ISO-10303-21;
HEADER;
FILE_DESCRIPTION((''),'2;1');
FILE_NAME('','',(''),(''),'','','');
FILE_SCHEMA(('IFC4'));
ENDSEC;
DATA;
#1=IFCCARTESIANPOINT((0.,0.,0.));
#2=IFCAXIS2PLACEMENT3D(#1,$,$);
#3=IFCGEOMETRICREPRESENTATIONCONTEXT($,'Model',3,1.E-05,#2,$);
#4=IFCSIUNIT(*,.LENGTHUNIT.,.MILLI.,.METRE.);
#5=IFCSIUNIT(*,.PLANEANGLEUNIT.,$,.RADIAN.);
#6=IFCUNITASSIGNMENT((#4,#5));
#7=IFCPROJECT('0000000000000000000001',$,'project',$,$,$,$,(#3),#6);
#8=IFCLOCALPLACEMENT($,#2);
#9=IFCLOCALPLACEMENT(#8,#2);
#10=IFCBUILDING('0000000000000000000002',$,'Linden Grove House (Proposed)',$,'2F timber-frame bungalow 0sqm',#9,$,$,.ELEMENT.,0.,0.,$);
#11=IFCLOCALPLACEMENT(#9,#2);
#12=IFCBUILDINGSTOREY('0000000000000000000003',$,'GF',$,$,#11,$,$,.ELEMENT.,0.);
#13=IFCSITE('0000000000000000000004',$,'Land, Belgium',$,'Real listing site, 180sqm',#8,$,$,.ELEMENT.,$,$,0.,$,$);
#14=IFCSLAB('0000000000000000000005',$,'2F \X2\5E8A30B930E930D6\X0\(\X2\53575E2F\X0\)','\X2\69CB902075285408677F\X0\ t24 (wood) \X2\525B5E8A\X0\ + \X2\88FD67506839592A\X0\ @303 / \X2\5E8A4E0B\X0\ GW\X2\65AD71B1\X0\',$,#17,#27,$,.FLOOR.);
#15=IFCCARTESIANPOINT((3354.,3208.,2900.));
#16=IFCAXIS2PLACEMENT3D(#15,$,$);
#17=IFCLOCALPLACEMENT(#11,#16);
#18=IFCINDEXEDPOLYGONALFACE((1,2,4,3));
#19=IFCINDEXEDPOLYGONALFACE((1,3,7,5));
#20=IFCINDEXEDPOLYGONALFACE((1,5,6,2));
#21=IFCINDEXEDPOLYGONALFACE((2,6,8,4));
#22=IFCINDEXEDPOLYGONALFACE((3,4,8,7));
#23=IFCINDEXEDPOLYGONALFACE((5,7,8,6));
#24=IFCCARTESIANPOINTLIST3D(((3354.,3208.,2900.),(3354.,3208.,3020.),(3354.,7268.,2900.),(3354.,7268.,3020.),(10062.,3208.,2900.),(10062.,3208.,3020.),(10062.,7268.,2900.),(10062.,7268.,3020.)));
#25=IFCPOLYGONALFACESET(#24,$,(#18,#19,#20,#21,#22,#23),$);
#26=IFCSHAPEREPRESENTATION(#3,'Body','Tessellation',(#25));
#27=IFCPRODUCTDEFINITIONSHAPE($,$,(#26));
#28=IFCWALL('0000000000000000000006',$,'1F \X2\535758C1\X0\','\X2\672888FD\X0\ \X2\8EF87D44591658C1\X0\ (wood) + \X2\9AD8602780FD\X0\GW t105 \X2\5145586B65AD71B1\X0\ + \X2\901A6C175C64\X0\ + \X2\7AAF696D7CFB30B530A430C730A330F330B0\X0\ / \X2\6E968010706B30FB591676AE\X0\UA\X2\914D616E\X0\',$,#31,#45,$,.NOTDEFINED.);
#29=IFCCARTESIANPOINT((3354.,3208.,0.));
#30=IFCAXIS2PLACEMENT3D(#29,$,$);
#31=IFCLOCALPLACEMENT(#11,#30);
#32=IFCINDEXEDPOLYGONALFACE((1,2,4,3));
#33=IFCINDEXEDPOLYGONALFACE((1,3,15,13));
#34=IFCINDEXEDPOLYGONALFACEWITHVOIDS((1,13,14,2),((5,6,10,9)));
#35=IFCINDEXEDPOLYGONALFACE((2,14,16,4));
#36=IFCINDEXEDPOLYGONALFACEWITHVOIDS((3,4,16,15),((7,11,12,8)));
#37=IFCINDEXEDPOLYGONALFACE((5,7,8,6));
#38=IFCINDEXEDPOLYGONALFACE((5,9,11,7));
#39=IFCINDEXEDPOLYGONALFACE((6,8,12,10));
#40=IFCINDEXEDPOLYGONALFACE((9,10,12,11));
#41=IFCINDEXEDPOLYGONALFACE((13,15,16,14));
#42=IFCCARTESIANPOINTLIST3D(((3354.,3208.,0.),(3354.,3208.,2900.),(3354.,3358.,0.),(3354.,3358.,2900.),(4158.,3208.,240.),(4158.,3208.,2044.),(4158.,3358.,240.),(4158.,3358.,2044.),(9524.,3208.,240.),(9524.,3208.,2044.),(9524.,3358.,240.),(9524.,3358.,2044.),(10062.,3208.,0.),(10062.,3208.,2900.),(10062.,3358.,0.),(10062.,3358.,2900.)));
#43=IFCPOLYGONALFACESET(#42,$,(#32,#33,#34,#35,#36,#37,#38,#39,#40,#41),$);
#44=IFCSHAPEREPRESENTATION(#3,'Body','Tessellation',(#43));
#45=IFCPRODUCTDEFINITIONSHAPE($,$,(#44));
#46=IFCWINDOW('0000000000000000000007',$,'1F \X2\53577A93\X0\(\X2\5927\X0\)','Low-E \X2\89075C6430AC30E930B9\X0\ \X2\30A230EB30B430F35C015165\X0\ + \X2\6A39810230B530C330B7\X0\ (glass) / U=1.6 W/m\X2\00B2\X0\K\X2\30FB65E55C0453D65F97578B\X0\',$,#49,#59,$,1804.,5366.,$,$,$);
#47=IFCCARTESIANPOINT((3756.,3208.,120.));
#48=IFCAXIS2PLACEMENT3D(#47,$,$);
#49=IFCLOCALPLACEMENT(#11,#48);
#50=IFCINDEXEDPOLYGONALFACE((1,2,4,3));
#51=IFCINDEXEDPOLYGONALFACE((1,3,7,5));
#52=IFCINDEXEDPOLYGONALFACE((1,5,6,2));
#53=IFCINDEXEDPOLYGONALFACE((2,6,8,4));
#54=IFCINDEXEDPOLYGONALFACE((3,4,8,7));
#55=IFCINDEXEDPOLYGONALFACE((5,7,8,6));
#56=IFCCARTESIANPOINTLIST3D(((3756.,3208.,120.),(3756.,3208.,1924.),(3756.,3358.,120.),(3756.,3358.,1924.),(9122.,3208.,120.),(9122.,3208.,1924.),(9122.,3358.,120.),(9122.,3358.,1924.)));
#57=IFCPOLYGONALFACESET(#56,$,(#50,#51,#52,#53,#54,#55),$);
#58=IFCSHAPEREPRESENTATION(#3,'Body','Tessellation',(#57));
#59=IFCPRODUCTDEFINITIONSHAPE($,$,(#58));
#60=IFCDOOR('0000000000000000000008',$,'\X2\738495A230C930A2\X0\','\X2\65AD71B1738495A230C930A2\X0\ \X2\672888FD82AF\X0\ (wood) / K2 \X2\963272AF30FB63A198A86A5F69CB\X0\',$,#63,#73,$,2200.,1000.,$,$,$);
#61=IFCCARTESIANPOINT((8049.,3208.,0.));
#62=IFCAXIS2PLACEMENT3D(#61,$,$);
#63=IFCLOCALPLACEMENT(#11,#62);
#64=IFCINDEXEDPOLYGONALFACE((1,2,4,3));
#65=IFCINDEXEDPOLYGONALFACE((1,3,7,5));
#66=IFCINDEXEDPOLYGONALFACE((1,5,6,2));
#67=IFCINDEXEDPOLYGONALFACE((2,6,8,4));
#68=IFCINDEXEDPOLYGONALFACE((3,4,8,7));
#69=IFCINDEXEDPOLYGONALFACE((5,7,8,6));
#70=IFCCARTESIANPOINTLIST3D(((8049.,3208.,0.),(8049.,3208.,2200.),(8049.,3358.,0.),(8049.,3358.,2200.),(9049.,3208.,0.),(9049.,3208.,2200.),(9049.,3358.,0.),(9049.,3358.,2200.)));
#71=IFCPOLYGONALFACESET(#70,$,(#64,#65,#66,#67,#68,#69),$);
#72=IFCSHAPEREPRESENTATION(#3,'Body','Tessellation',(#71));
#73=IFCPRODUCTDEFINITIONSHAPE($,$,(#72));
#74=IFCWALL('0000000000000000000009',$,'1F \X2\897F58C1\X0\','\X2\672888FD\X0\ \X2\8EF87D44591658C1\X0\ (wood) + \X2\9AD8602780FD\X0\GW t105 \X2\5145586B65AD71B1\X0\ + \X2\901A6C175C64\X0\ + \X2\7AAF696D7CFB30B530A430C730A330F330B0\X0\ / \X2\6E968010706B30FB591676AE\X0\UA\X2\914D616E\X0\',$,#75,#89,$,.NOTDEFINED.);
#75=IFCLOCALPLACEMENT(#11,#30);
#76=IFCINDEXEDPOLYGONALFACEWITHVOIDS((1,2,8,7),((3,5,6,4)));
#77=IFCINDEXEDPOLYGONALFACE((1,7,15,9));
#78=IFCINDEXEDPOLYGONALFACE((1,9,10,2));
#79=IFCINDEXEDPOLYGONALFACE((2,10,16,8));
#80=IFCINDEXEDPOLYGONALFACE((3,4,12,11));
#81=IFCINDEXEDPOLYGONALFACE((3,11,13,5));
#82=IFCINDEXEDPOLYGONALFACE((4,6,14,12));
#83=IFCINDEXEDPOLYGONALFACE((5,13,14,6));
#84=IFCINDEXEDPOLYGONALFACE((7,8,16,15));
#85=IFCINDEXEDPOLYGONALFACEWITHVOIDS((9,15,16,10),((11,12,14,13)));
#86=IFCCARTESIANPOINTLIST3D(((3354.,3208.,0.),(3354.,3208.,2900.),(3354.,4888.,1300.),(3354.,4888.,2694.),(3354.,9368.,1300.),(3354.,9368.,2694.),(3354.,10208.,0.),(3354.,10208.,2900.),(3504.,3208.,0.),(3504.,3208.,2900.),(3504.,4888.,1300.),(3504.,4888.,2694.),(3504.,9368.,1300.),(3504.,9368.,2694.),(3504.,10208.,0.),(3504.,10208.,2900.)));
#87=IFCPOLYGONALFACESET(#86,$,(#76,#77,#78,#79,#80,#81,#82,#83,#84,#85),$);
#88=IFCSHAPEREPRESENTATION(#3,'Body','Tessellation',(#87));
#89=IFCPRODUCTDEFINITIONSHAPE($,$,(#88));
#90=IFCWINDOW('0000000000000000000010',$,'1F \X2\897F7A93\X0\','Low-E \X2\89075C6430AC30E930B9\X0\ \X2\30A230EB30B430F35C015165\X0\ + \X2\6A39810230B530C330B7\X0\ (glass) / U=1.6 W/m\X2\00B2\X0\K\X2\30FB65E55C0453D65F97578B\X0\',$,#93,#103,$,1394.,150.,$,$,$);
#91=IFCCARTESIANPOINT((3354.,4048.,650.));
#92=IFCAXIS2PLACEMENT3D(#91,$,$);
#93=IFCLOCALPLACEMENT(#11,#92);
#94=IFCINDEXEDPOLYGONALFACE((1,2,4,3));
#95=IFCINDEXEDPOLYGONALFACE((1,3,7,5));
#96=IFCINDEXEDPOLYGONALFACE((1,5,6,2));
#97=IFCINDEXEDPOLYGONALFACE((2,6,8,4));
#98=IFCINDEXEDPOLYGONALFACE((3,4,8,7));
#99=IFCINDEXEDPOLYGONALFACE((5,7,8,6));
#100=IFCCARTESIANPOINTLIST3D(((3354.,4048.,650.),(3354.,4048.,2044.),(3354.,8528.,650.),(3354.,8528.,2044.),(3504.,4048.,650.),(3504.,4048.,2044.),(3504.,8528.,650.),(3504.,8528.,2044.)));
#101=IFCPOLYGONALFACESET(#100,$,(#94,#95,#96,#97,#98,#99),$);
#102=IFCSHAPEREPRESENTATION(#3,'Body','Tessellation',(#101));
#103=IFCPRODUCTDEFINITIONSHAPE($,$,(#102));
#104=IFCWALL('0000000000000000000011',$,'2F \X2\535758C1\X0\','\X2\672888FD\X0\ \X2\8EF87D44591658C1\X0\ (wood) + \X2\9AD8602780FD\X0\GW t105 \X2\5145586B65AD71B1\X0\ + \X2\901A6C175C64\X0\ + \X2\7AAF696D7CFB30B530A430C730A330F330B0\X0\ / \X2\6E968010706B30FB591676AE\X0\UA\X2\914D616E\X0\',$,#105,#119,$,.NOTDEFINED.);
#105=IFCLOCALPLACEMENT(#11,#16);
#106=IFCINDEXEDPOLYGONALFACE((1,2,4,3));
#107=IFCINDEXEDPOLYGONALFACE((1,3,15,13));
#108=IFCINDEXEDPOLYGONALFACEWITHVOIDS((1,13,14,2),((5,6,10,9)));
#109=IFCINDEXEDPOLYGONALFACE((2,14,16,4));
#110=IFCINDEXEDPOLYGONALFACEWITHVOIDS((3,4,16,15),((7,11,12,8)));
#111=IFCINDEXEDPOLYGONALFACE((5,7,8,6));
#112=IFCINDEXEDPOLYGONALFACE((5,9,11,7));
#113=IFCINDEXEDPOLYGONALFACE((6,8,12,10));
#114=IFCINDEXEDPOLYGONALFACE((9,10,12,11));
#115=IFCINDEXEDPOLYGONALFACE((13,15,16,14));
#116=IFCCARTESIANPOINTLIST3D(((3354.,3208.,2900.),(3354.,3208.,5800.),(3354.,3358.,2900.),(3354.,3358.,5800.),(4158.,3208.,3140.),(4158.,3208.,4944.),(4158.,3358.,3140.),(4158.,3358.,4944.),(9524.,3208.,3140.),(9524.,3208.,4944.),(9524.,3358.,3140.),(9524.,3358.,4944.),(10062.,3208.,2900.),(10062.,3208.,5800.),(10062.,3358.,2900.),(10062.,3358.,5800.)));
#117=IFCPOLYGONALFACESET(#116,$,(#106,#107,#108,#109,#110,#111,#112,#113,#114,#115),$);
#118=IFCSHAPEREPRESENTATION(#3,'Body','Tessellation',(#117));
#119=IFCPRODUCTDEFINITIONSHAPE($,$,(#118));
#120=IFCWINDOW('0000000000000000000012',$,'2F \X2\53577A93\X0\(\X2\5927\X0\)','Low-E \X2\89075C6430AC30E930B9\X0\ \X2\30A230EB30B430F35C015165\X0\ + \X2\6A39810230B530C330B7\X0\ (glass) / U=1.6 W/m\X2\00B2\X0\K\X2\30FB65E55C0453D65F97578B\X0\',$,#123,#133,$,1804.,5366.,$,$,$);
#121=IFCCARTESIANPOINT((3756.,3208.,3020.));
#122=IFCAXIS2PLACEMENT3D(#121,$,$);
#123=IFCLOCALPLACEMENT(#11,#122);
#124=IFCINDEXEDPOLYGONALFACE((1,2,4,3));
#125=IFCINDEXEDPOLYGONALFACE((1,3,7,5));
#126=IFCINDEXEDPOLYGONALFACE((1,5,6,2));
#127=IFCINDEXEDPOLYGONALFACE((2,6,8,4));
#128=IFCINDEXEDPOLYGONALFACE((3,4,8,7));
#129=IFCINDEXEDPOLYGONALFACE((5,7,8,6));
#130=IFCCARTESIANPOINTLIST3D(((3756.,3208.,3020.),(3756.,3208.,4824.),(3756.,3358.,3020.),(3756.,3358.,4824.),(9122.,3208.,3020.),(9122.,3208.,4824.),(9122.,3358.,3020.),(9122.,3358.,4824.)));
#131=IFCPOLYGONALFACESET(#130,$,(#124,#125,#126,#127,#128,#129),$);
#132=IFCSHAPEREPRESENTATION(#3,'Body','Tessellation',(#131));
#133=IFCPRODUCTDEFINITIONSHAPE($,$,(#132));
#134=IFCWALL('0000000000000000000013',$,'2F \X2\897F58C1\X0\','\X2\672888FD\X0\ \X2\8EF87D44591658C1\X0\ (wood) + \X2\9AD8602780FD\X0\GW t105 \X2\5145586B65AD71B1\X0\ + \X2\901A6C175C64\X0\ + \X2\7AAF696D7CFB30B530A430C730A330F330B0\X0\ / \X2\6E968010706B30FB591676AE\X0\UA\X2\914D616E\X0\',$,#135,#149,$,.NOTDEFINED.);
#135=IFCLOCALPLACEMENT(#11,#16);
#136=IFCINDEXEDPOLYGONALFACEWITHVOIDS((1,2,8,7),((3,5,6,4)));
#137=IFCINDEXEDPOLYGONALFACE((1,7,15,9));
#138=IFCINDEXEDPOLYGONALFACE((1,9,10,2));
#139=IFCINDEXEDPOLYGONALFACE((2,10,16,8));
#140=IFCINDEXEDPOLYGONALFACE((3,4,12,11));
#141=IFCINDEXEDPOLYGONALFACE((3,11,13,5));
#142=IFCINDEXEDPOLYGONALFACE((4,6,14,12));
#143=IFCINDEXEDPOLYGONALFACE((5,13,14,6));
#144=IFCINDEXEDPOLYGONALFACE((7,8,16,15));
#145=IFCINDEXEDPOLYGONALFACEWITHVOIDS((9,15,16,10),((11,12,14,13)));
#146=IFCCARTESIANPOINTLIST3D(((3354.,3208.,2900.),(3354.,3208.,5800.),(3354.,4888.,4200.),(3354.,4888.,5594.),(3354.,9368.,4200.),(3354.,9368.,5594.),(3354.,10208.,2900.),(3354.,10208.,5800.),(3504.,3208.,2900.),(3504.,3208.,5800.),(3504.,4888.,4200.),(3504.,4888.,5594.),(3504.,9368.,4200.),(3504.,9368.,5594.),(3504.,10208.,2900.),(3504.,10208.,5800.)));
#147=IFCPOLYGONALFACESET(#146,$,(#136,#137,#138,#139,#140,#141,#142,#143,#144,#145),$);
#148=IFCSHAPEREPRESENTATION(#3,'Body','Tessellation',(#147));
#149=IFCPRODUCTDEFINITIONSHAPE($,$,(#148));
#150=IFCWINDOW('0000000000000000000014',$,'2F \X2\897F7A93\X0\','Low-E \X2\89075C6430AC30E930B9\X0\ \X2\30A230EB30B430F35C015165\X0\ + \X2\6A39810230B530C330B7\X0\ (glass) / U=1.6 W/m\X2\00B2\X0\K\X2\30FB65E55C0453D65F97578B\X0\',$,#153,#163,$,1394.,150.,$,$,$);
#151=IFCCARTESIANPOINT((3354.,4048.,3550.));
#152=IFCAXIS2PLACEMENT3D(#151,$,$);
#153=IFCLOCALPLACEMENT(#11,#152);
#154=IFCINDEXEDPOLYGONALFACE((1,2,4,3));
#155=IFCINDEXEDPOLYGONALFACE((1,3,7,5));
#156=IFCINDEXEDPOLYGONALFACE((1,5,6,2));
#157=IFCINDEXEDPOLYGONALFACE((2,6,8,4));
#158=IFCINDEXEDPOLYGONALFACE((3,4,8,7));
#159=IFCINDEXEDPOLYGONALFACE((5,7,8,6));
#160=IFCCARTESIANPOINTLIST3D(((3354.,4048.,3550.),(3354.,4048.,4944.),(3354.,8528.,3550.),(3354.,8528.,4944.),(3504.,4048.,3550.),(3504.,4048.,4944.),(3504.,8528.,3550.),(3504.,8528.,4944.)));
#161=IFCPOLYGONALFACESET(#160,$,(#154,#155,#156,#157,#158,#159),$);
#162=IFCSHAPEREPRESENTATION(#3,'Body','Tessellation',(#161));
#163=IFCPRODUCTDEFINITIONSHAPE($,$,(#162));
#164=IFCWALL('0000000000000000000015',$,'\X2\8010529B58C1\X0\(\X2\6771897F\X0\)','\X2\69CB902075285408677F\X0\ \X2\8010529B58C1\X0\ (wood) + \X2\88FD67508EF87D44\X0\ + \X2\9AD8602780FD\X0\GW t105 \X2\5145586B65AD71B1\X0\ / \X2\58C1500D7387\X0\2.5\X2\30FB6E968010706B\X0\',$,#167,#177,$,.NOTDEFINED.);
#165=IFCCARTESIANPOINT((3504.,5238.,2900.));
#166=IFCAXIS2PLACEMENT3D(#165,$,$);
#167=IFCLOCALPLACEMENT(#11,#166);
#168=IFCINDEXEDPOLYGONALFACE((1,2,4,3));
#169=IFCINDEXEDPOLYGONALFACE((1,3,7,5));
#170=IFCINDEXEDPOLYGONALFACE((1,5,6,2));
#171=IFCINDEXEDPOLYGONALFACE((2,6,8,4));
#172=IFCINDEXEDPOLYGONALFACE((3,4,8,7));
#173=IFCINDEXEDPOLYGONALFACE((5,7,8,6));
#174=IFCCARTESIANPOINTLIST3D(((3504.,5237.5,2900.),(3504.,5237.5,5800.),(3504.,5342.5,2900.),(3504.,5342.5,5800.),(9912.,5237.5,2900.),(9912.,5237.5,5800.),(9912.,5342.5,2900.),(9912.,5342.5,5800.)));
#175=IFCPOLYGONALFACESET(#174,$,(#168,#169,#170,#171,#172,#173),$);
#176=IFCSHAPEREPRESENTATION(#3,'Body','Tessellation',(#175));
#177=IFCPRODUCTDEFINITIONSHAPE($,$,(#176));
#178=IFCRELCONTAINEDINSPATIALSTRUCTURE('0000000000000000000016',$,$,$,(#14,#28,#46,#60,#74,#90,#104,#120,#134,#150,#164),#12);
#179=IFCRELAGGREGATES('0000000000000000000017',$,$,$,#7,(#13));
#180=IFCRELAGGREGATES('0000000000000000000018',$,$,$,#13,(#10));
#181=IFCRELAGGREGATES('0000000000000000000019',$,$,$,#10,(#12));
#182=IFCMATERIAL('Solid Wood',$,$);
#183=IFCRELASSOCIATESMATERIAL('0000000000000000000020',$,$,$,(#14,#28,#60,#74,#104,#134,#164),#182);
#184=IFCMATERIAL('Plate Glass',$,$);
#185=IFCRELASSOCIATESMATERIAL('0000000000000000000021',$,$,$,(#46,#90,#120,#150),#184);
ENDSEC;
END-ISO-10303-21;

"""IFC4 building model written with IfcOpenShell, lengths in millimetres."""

from ifc_helpers import new_model, si_unit, frame, frame_2d, origin, place, context, project, spatial, rectangle, extrude, material, element, fill, save


model = new_model("IFC4")

# Units and contexts
model_context = context("Model", 3, precision=1e-05, world=origin())
ifc_project = project(units=[si_unit("LENGTHUNIT", "METRE", prefix="MILLI"), si_unit("PLANEANGLEUNIT", "RADIAN")], contexts=[model_context])

# Site, building, storey
site_placement = place(None, origin())
site = spatial("IfcSite", under=ifc_project, at=site_placement, Name="Land, Belgium", ObjectType="Real listing site, 180sqm", CompositionType="ELEMENT", RefElevation=0.0)
building_placement = place(site_placement, origin())
building = spatial("IfcBuilding", under=site, at=building_placement, Name="Linden Grove House (Proposed)", ObjectType="2F timber-frame bungalow 0sqm", CompositionType="ELEMENT", ElevationOfRefHeight=0.0, ElevationOfTerrain=0.0)
storey_placement = place(building_placement, origin())
storey = spatial("IfcBuildingStorey", under=building, at=storey_placement, Name="GF", CompositionType="ELEMENT", Elevation=0.0)

# Slab
ifc_material_1 = material(Name="Solid Wood")
slab_1_placement = place(storey_placement, frame((3354.0, 3208.0, 2900.0)))
element("IfcSlab", 1, at=slab_1_placement, inside=storey, material=ifc_material_1, Name="2F 床スラブ(南帯)", Description="構造用合板 t24 (wood) 剛床 + 製材根太 @303 / 床下 GW断熱", PredefinedType="FLOOR", context=model_context, shape_type="SweptSolid", body=[
    extrude(rectangle(XDim=6708.0, YDim=4060.0, at=frame_2d((3354.0, 2030.0))), frame((3354.0, 3208.0, 2900.0)), (0.0, 0.0, 1.0), 120.0),
])

# Wall, openings, window, door
wall_1_placement = place(storey_placement, frame((3354.0, 3208.0, 0.0)))
wall_1 = element("IfcWall", 2, at=wall_1_placement, inside=storey, material=ifc_material_1, Name="1F 南壁", Description="木製 軸組外壁 (wood) + 高性能GW t105 充填断熱 + 通気層 + 窯業系サイディング / 準耐火・外皮UA配慮", PredefinedType="NOTDEFINED", context=model_context, shape_type="SweptSolid", body=[
    extrude(rectangle(XDim=6708.0, YDim=150.0, at=frame_2d((3354.0, 75.0))), frame((3354.0, 3208.0, 0.0)), (0.0, 0.0, 1.0), 2900.0),
])
opening_1_placement = place(storey_placement, frame((3756.0, 3208.0, 120.0)))
opening_1 = element("IfcOpeningElement", 3, at=opening_1_placement, cuts=wall_1, PredefinedType="NOTDEFINED", context=model_context, shape_type="SweptSolid", body=[
    extrude(rectangle(XDim=5366.0, YDim=150.0, at=frame_2d((2683.0, 75.0))), frame((3756.0, 3208.0, 120.0)), (0.0, 0.0, 1.0), 1804.0),
])
opening_2_placement = place(storey_placement, frame((8049.0, 3208.0, 0.0)))
opening_2 = element("IfcOpeningElement", 4, at=opening_2_placement, cuts=wall_1, PredefinedType="NOTDEFINED", context=model_context, shape_type="SweptSolid", body=[
    extrude(rectangle(XDim=1000.0, YDim=150.0, at=frame_2d((500.0, 75.0))), frame((8049.0, 3208.0, 0.0)), (0.0, 0.0, 1.0), 2200.0),
])
ifc_material_2 = material(Name="Plate Glass")
window_1_placement = place(storey_placement, frame((3756.0, 3208.0, 120.0)))
window_1 = element("IfcWindow", 5, at=window_1_placement, inside=storey, material=ifc_material_2, Name="1F 南窓(大)", Description="Low-E 複層ガラス アルゴン封入 + 樹脂サッシ (glass) / U=1.6 W/m²K・日射取得型", OverallHeight=1804.0, OverallWidth=5366.0, context=model_context, shape_type="SweptSolid", body=[
    extrude(rectangle(XDim=5366.0, YDim=150.0, at=frame_2d((2683.0, 75.0))), frame((3756.0, 3208.0, 120.0)), (0.0, 0.0, 1.0), 1804.0),
])
fill(opening_1, window_1)
door_placement = place(storey_placement, frame((8049.0, 3208.0, 0.0)))
door = element("IfcDoor", 6, at=door_placement, inside=storey, material=ifc_material_1, Name="玄関ドア", Description="断熱玄関ドア 木製芯 (wood) / K2 防犯・採風機構", OverallHeight=2200.0, OverallWidth=1000.0, context=model_context, shape_type="SweptSolid", body=[
    extrude(rectangle(XDim=1000.0, YDim=150.0, at=frame_2d((500.0, 75.0))), frame((8049.0, 3208.0, 0.0)), (0.0, 0.0, 1.0), 2200.0),
])
fill(opening_2, door)

# Wall, opening, window
wall_2_placement = place(storey_placement, frame((3354.0, 3208.0, 0.0)))
wall_2 = element("IfcWall", 7, at=wall_2_placement, inside=storey, material=ifc_material_1, Name="1F 西壁", Description="木製 軸組外壁 (wood) + 高性能GW t105 充填断熱 + 通気層 + 窯業系サイディング / 準耐火・外皮UA配慮", PredefinedType="NOTDEFINED", context=model_context, shape_type="SweptSolid", body=[
    extrude(rectangle(XDim=150.0, YDim=7000.0, at=frame_2d((75.0, 3500.0))), frame((3354.0, 3208.0, 0.0)), (0.0, 0.0, 1.0), 2900.0),
])
opening_3_placement = place(storey_placement, frame((3354.0, 4048.0, 650.0)))
opening_3 = element("IfcOpeningElement", 8, at=opening_3_placement, cuts=wall_2, PredefinedType="NOTDEFINED", context=model_context, shape_type="SweptSolid", body=[
    extrude(rectangle(XDim=150.0, YDim=4480.0, at=frame_2d((75.0, 2240.0))), frame((3354.0, 4048.0, 650.0)), (0.0, 0.0, 1.0), 1394.0),
])
window_2_placement = place(storey_placement, frame((3354.0, 4048.0, 650.0)))
window_2 = element("IfcWindow", 9, at=window_2_placement, inside=storey, material=ifc_material_2, Name="1F 西窓", Description="Low-E 複層ガラス アルゴン封入 + 樹脂サッシ (glass) / U=1.6 W/m²K・日射取得型", OverallHeight=1394.0, OverallWidth=150.0, context=model_context, shape_type="SweptSolid", body=[
    extrude(rectangle(XDim=150.0, YDim=4480.0, at=frame_2d((75.0, 2240.0))), frame((3354.0, 4048.0, 650.0)), (0.0, 0.0, 1.0), 1394.0),
])
fill(opening_3, window_2)

# Walls, openings, windows
wall_3_placement = place(storey_placement, frame((3354.0, 3208.0, 2900.0)))
wall_3 = element("IfcWall", 10, at=wall_3_placement, inside=storey, material=ifc_material_1, Name="2F 南壁", Description="木製 軸組外壁 (wood) + 高性能GW t105 充填断熱 + 通気層 + 窯業系サイディング / 準耐火・外皮UA配慮", PredefinedType="NOTDEFINED", context=model_context, shape_type="SweptSolid", body=[
    extrude(rectangle(XDim=6708.0, YDim=150.0, at=frame_2d((3354.0, 75.0))), frame((3354.0, 3208.0, 2900.0)), (0.0, 0.0, 1.0), 2900.0),
])
opening_4_placement = place(storey_placement, frame((3756.0, 3208.0, 3020.0)))
opening_4 = element("IfcOpeningElement", 11, at=opening_4_placement, cuts=wall_3, PredefinedType="NOTDEFINED", context=model_context, shape_type="SweptSolid", body=[
    extrude(rectangle(XDim=5366.0, YDim=150.0, at=frame_2d((2683.0, 75.0))), frame((3756.0, 3208.0, 3020.0)), (0.0, 0.0, 1.0), 1804.0),
])
window_3_placement = place(storey_placement, frame((3756.0, 3208.0, 3020.0)))
window_3 = element("IfcWindow", 12, at=window_3_placement, inside=storey, material=ifc_material_2, Name="2F 南窓(大)", Description="Low-E 複層ガラス アルゴン封入 + 樹脂サッシ (glass) / U=1.6 W/m²K・日射取得型", OverallHeight=1804.0, OverallWidth=5366.0, context=model_context, shape_type="SweptSolid", body=[
    extrude(rectangle(XDim=5366.0, YDim=150.0, at=frame_2d((2683.0, 75.0))), frame((3756.0, 3208.0, 3020.0)), (0.0, 0.0, 1.0), 1804.0),
])
fill(opening_4, window_3)
wall_4_placement = place(storey_placement, frame((3354.0, 3208.0, 2900.0)))
wall_4 = element("IfcWall", 13, at=wall_4_placement, inside=storey, material=ifc_material_1, Name="2F 西壁", Description="木製 軸組外壁 (wood) + 高性能GW t105 充填断熱 + 通気層 + 窯業系サイディング / 準耐火・外皮UA配慮", PredefinedType="NOTDEFINED", context=model_context, shape_type="SweptSolid", body=[
    extrude(rectangle(XDim=150.0, YDim=7000.0, at=frame_2d((75.0, 3500.0))), frame((3354.0, 3208.0, 2900.0)), (0.0, 0.0, 1.0), 2900.0),
])
opening_5_placement = place(storey_placement, frame((3354.0, 4048.0, 3550.0)))
opening_5 = element("IfcOpeningElement", 14, at=opening_5_placement, cuts=wall_4, PredefinedType="NOTDEFINED", context=model_context, shape_type="SweptSolid", body=[
    extrude(rectangle(XDim=150.0, YDim=4480.0, at=frame_2d((75.0, 2240.0))), frame((3354.0, 4048.0, 3550.0)), (0.0, 0.0, 1.0), 1394.0),
])
window_4_placement = place(storey_placement, frame((3354.0, 4048.0, 3550.0)))
window_4 = element("IfcWindow", 15, at=window_4_placement, inside=storey, material=ifc_material_2, Name="2F 西窓", Description="Low-E 複層ガラス アルゴン封入 + 樹脂サッシ (glass) / U=1.6 W/m²K・日射取得型", OverallHeight=1394.0, OverallWidth=150.0, context=model_context, shape_type="SweptSolid", body=[
    extrude(rectangle(XDim=150.0, YDim=4480.0, at=frame_2d((75.0, 2240.0))), frame((3354.0, 4048.0, 3550.0)), (0.0, 0.0, 1.0), 1394.0),
])
fill(opening_5, window_4)

# Wall
wall_5_placement = place(storey_placement, frame((3504.0, 5238.0, 2900.0)))
element("IfcWall", 16, at=wall_5_placement, inside=storey, material=ifc_material_1, Name="耐力壁(東西)", Description="構造用合板 耐力壁 (wood) + 製材軸組 + 高性能GW t105 充填断熱 / 壁倍率2.5・準耐火", PredefinedType="NOTDEFINED", context=model_context, shape_type="SweptSolid", body=[
    extrude(rectangle(XDim=6408.0, YDim=105.0, at=frame_2d((3204.0, 52.0))), frame((3504.0, 5238.0, 2900.0)), (0.0, 0.0, 1.0), 2900.0),
])

save(model, "model.ifc")
